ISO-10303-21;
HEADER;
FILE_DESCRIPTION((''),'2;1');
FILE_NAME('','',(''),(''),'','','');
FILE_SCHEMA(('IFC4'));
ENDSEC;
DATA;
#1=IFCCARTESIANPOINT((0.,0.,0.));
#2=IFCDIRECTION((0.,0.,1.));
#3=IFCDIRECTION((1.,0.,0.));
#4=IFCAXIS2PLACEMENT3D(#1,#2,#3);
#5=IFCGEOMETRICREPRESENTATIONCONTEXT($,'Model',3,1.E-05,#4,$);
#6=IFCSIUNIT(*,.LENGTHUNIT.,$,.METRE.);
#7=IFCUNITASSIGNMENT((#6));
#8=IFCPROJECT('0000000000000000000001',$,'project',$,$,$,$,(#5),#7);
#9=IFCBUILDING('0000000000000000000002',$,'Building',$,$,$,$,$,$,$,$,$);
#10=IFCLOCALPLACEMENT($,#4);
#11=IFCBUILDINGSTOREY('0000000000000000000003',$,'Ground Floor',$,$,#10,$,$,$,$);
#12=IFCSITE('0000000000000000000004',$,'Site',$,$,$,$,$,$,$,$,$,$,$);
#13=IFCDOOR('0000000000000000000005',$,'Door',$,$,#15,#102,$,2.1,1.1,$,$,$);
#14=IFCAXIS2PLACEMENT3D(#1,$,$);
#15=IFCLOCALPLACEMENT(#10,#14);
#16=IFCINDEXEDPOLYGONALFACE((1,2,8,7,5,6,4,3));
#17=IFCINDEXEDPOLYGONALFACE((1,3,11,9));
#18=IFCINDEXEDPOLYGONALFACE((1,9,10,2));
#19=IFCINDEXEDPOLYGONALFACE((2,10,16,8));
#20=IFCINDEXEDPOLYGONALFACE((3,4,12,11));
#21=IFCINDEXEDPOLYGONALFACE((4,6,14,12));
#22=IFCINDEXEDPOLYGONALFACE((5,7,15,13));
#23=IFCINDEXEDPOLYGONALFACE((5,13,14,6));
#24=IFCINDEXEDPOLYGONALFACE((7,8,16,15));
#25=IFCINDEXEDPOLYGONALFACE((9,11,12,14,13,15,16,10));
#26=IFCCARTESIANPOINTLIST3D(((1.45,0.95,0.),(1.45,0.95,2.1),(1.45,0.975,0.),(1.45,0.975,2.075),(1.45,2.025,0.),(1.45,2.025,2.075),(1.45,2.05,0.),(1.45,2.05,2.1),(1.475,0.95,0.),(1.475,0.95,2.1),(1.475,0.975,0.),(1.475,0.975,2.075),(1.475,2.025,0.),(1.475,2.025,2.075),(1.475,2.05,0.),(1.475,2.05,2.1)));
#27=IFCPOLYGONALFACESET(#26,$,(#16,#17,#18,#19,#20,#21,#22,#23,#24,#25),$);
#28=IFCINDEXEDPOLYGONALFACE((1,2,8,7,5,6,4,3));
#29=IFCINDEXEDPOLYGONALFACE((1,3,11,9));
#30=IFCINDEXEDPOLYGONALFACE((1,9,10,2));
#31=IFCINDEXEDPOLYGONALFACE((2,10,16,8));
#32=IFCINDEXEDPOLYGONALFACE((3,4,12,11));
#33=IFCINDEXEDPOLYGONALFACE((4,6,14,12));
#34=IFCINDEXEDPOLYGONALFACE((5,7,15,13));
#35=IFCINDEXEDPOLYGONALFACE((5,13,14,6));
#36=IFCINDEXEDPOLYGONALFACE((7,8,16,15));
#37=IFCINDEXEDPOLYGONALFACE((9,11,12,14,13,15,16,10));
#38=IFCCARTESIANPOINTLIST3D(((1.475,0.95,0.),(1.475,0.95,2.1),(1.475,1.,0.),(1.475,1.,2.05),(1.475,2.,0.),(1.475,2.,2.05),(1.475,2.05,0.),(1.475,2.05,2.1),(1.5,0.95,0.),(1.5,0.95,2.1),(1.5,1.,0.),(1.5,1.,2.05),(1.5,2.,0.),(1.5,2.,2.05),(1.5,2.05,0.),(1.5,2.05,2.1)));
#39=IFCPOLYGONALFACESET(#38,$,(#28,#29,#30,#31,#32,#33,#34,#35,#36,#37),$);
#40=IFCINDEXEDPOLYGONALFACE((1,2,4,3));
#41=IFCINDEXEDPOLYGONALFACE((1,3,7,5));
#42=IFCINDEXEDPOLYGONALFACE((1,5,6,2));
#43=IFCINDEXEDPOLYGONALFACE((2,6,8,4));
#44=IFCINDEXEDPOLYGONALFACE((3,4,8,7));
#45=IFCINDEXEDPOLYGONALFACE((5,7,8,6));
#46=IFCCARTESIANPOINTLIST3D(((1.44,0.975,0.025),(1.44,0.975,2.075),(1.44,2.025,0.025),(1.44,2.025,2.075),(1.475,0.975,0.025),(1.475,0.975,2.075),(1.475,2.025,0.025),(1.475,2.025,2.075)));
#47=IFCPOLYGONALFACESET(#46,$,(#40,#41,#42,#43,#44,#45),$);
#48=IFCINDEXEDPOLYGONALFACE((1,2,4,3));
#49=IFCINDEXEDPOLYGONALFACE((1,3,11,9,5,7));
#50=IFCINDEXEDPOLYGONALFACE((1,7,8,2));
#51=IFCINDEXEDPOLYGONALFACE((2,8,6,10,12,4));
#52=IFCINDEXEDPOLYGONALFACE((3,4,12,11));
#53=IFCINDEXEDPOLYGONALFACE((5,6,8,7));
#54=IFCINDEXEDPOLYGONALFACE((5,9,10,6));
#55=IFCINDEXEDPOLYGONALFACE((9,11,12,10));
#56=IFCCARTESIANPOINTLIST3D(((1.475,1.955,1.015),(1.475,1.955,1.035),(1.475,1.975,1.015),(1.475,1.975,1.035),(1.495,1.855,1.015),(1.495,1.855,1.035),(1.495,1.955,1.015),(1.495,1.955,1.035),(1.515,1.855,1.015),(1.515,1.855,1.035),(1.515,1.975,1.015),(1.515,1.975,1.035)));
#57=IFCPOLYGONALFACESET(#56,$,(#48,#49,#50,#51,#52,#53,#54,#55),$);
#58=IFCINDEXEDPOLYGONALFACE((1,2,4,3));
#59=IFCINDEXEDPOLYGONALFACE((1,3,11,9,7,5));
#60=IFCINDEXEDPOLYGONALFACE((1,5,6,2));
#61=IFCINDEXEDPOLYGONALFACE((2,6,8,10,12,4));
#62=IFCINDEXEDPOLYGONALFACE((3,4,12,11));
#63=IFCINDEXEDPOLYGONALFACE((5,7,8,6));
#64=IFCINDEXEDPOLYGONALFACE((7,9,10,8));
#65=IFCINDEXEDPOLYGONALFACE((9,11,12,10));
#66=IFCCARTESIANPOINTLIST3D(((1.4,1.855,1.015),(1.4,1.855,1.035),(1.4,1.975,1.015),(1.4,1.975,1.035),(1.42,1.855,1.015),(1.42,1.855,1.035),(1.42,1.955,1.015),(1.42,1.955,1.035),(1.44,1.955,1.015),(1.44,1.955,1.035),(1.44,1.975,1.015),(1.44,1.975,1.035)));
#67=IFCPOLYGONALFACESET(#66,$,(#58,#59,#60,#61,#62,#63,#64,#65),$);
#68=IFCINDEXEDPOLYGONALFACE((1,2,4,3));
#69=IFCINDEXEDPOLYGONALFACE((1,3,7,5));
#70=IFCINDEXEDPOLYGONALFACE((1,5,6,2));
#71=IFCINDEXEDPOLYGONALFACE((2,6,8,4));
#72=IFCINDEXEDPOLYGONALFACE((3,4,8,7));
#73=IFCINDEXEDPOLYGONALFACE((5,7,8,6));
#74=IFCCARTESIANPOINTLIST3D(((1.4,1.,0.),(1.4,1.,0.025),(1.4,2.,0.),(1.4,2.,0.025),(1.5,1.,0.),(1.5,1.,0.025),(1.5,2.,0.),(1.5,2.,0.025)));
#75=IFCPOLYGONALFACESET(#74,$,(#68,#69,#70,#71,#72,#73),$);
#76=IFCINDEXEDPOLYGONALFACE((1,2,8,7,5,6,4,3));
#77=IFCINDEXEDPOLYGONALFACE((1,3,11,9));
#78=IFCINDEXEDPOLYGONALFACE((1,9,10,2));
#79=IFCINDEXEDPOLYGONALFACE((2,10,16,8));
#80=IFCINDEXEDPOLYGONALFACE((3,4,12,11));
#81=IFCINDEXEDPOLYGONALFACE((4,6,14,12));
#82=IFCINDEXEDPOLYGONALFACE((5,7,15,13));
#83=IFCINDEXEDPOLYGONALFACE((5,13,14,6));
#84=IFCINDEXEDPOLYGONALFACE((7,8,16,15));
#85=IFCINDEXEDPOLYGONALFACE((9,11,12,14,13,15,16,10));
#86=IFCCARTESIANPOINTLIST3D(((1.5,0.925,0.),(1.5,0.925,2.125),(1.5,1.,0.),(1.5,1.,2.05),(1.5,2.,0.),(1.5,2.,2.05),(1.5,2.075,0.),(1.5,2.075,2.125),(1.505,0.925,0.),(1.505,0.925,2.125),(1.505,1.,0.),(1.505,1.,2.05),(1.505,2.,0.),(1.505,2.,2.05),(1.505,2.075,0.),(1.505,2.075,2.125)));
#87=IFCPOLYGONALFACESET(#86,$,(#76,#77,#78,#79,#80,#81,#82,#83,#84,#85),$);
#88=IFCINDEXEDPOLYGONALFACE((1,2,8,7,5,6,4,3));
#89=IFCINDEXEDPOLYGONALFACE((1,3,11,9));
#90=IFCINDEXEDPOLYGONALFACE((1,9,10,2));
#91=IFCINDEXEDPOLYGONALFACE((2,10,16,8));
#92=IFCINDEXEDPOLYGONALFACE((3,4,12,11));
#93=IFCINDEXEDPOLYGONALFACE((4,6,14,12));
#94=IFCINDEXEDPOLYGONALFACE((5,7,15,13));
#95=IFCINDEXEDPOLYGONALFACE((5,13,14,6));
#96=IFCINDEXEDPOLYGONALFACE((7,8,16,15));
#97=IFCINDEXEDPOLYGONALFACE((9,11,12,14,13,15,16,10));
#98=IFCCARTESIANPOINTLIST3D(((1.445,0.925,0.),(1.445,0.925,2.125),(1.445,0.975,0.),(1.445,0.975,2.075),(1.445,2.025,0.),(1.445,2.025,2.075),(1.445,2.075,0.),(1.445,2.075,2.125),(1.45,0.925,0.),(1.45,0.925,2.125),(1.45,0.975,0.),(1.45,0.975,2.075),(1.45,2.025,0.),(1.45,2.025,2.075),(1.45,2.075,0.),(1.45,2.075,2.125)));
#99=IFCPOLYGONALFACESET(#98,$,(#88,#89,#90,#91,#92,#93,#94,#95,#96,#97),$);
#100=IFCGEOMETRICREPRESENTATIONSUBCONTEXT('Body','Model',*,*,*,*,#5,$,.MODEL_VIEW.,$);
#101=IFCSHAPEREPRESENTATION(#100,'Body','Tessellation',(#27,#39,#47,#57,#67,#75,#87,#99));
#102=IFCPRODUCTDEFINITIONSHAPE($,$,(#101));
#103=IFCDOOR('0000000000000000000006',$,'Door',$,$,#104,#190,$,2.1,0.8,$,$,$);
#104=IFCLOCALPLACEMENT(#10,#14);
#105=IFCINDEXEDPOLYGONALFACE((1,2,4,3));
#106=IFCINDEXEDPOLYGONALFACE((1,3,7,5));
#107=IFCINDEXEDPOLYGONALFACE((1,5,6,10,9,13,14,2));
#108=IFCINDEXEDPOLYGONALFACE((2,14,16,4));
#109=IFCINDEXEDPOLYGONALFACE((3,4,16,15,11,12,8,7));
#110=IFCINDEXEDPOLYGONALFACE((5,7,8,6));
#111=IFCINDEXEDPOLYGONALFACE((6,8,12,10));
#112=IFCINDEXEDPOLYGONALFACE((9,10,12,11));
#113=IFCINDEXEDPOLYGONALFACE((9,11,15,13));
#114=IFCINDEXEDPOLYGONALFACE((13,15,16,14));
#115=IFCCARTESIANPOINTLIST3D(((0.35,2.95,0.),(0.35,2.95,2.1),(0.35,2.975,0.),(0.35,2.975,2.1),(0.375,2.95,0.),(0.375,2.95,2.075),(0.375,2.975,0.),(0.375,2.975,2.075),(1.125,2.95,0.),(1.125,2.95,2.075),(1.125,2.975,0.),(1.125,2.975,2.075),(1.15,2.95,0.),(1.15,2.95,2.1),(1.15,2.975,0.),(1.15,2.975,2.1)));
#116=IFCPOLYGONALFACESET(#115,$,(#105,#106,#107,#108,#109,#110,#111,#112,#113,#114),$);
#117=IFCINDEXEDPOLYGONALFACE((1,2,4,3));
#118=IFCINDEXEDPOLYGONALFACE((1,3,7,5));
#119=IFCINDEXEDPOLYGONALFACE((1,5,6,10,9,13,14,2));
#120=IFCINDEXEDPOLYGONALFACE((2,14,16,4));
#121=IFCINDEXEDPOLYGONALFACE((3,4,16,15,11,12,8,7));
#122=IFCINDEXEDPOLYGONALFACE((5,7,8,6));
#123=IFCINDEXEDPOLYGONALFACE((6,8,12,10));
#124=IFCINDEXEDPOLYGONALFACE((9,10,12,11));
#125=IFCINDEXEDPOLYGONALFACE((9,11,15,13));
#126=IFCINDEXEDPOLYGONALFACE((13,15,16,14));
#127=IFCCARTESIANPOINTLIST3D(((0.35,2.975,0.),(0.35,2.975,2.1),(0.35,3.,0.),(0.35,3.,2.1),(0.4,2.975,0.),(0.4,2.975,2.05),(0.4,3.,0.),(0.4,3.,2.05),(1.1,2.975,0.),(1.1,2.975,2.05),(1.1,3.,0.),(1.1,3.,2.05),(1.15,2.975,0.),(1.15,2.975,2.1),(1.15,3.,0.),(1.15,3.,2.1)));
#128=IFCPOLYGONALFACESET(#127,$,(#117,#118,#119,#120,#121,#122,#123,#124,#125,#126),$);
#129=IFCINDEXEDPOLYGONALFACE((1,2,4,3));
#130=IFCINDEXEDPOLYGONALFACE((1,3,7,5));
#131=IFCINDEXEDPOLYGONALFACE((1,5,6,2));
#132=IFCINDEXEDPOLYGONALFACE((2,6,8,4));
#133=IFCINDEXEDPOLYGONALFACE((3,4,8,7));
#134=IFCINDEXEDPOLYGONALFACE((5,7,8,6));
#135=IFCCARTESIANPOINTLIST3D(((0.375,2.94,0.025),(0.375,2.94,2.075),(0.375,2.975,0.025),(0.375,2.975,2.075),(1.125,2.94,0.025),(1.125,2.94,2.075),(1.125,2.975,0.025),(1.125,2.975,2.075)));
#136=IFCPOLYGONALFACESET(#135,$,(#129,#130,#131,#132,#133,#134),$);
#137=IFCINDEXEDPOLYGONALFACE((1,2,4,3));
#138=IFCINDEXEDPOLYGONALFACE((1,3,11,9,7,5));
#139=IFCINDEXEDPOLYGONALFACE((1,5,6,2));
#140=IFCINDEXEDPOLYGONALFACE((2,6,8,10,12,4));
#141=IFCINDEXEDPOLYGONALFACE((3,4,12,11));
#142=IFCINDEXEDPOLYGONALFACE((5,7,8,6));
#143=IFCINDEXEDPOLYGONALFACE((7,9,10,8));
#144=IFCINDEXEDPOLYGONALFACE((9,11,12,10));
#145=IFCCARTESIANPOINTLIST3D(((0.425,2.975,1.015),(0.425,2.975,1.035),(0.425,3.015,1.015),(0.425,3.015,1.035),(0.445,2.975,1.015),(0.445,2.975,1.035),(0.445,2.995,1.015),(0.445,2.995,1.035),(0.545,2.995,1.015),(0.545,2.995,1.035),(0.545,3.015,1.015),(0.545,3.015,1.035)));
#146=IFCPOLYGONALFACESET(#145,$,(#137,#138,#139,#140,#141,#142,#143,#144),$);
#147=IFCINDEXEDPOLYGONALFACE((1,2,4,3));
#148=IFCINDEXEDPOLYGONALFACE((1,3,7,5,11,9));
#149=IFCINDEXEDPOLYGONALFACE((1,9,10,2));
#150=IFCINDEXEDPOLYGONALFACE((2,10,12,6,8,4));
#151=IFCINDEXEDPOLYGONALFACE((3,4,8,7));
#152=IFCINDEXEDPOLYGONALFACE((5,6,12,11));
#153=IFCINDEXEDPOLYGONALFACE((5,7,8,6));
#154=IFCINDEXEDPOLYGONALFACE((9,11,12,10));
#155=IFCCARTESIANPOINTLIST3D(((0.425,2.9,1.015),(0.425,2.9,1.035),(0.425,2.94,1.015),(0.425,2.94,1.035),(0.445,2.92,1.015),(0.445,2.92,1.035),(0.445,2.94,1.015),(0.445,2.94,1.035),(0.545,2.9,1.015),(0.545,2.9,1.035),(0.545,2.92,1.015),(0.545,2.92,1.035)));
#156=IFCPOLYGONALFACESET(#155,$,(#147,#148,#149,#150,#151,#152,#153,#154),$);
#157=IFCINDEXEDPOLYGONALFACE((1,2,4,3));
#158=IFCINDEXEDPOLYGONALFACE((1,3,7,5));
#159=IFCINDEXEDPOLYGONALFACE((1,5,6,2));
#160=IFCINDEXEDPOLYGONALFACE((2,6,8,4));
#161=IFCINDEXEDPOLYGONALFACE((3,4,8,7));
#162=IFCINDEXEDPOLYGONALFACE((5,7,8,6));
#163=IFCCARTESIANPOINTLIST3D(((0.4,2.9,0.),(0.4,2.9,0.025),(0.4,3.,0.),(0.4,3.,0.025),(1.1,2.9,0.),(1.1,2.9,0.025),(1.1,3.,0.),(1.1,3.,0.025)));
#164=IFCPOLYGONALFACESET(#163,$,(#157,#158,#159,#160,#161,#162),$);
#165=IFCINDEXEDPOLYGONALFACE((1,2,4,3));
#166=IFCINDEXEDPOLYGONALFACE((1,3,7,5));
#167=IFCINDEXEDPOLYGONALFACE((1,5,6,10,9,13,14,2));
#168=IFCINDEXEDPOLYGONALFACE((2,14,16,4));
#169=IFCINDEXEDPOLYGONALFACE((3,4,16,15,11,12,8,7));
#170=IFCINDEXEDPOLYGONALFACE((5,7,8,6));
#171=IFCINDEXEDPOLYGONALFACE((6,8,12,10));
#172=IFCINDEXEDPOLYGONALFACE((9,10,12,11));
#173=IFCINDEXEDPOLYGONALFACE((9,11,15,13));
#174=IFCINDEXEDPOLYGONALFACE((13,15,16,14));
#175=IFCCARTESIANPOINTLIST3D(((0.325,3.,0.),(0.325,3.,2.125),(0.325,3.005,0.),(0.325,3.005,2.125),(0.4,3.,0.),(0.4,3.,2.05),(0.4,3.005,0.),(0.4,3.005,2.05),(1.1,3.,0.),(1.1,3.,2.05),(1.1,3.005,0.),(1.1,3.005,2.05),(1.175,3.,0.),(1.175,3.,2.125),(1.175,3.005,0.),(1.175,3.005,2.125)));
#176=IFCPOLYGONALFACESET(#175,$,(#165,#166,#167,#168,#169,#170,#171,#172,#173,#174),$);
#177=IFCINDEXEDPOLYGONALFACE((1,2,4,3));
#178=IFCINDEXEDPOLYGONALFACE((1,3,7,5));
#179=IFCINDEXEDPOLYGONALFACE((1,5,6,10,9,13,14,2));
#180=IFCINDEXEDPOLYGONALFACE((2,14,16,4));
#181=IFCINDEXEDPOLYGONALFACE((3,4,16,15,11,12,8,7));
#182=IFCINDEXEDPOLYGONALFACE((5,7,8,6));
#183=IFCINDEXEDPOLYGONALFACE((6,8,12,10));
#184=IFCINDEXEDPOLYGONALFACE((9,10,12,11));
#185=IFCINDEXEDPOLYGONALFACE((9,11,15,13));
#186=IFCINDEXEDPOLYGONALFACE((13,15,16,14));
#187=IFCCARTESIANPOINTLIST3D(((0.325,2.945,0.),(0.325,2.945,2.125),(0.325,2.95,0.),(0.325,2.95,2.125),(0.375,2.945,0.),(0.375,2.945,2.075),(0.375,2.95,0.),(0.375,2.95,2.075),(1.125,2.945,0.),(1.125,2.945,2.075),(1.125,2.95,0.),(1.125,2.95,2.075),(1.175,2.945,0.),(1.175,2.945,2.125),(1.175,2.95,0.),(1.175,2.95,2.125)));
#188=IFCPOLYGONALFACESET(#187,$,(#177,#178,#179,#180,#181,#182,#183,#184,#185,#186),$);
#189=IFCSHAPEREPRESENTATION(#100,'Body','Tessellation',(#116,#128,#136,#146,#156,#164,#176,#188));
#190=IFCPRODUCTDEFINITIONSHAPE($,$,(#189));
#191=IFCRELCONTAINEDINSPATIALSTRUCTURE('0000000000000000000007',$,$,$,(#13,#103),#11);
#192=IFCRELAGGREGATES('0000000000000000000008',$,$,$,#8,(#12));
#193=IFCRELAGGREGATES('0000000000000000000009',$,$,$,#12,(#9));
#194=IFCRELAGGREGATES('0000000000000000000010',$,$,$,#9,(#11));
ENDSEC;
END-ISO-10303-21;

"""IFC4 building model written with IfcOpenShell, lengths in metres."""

from ifc_helpers import new_model, si_unit, frame, origin_with_axes, place, context, subcontext, project, spatial, line, indexed_curve, outline, extrude, element, save


model = new_model("IFC4")

# Units and contexts
model_context = context("Model", 3, precision=1e-05, world=origin_with_axes())
body_context = subcontext(model_context, "Body", "Model", "MODEL_VIEW")
ifc_project = project(units=[si_unit("LENGTHUNIT", "METRE")], contexts=[model_context])

# Site, building, storey
site = spatial("IfcSite", under=ifc_project, Name="Site")
building = spatial("IfcBuilding", under=site, Name="Building")
storey_placement = place(None, origin_with_axes())
storey = spatial("IfcBuildingStorey", under=building, at=storey_placement, Name="Ground Floor")

# Doors
door_1_placement = place(storey_placement, frame((1.5, 0.95, 0.0), z_axis=(0.0, 0.0, 1.0), x_axis=(0.0, 1.0, 0.0)))
element("IfcDoor", 1, at=door_1_placement, inside=storey, Name="Door", OverallHeight=2.1, OverallWidth=1.1, context=body_context, shape_type="SweptSolid", body=[
    extrude(outline(indexed_curve([(0.0, 0.0), (0.0, 2.1), (1.1, 2.1), (1.1, 0.0), (1.075, 0.0), (1.075, 2.075), (0.025, 2.075), (0.025, 0.0)], segments=[line(1, 2, 3, 4, 5, 6, 7, 8, 1)])), frame((0.0, 0.025, 0.0), z_axis=(0.0, -1.0, 0.0), x_axis=(1.0, 0.0, 0.0)), (0.0, 0.0, -1.0), 0.025),
    extrude(outline(indexed_curve([(0.0, 0.0), (0.0, 2.1), (1.1, 2.1), (1.1, 0.0), (1.05, 0.0), (1.05, 2.05), (0.05, 2.05), (0.05, 0.0)], segments=[line(1, 2, 3, 4, 5, 6, 7, 8, 1)])), frame((0.0, 0.0, 0.0), z_axis=(0.0, -1.0, 0.0), x_axis=(1.0, 0.0, 0.0)), (0.0, 0.0, -1.0), 0.025),
    extrude(outline(indexed_curve([(0.0, 0.0), (1.05, 0.0), (1.05, 0.035), (0.0, 0.035)], segments=[line(1, 2, 3, 4, 1)])), frame((0.025, 0.025, 0.025), z_axis=(0.0, 0.0, 1.0), x_axis=(1.0, 0.0, 0.0)), (0.0, 0.0, 1.0), 2.05),
    extrude(outline(indexed_curve([(0.0, 0.0), (0.0, -0.04), (-0.12, -0.04), (-0.12, -0.02), (-0.02, -0.02), (-0.02, 0.0)], segments=[line(1, 2, 3, 4, 5, 6, 1)])), frame((1.025, 0.025, 1.015), z_axis=(0.0, 0.0, 1.0), x_axis=(1.0, 0.0, 0.0)), (0.0, 0.0, 1.0), 0.02),
    extrude(outline(indexed_curve([(0.0, 0.0), (0.0, 0.04), (-0.12, 0.04), (-0.12, 0.02), (-0.02, 0.02), (-0.02, 0.0)], segments=[line(1, 2, 3, 4, 5, 6, 1)])), frame((1.025, 0.06, 1.015), z_axis=(0.0, 0.0, 1.0), x_axis=(1.0, 0.0, 0.0)), (0.0, 0.0, 1.0), 0.02),
    extrude(outline(indexed_curve([(0.0, 0.0), (1.0, 0.0), (1.0, 0.1), (0.0, 0.1)], segments=[line(1, 2, 3, 4, 1)])), frame((0.05, 0.0, 0.0), z_axis=(0.0, 0.0, 1.0), x_axis=(1.0, 0.0, 0.0)), (0.0, 0.0, 1.0), 0.025),
    extrude(outline(indexed_curve([(0.0, 0.0), (0.0, 2.125), (1.15, 2.125), (1.15, 0.0), (1.075, 0.0), (1.075, 2.05), (0.075, 2.05), (0.075, 0.0)], segments=[line(1, 2, 3, 4, 5, 6, 7, 8, 1)])), frame((-0.025, -0.005, 0.0), z_axis=(0.0, -1.0, 0.0), x_axis=(1.0, 0.0, 0.0)), (0.0, 0.0, -1.0), 0.005),
    extrude(outline(indexed_curve([(0.0, 0.0), (0.0, 2.125), (1.15, 2.125), (1.15, 0.0), (1.1, 0.0), (1.1, 2.075), (0.05, 2.075), (0.05, 0.0)], segments=[line(1, 2, 3, 4, 5, 6, 7, 8, 1)])), frame((-0.025, 0.05, 0.0), z_axis=(0.0, -1.0, 0.0), x_axis=(1.0, 0.0, 0.0)), (0.0, 0.0, -1.0), 0.005),
])
door_2_placement = place(storey_placement, frame((1.15, 3.0, 0.0), z_axis=(0.0, 0.0, 1.0), x_axis=(-1.0, 0.0, 0.0)))
element("IfcDoor", 2, at=door_2_placement, inside=storey, Name="Door", OverallHeight=2.1, OverallWidth=0.8, context=body_context, shape_type="SweptSolid", body=[
    extrude(outline(indexed_curve([(0.0, 0.0), (0.0, 2.1), (0.8, 2.1), (0.8, 0.0), (0.775, 0.0), (0.775, 2.075), (0.025, 2.075), (0.025, 0.0)], segments=[line(1, 2, 3, 4, 5, 6, 7, 8, 1)])), frame((0.0, 0.025, 0.0), z_axis=(0.0, -1.0, 0.0), x_axis=(1.0, 0.0, 0.0)), (0.0, 0.0, -1.0), 0.025),
    extrude(outline(indexed_curve([(0.0, 0.0), (0.0, 2.1), (0.8, 2.1), (0.8, 0.0), (0.75, 0.0), (0.75, 2.05), (0.05, 2.05), (0.05, 0.0)], segments=[line(1, 2, 3, 4, 5, 6, 7, 8, 1)])), frame((0.0, 0.0, 0.0), z_axis=(0.0, -1.0, 0.0), x_axis=(1.0, 0.0, 0.0)), (0.0, 0.0, -1.0), 0.025),
    extrude(outline(indexed_curve([(0.0, 0.0), (0.75, 0.0), (0.75, 0.035), (0.0, 0.035)], segments=[line(1, 2, 3, 4, 1)])), frame((0.025, 0.025, 0.025), z_axis=(0.0, 0.0, 1.0), x_axis=(1.0, 0.0, 0.0)), (0.0, 0.0, 1.0), 2.05),
    extrude(outline(indexed_curve([(0.0, 0.0), (0.0, -0.04), (-0.12, -0.04), (-0.12, -0.02), (-0.02, -0.02), (-0.02, 0.0)], segments=[line(1, 2, 3, 4, 5, 6, 1)])), frame((0.725, 0.025, 1.015), z_axis=(0.0, 0.0, 1.0), x_axis=(1.0, 0.0, 0.0)), (0.0, 0.0, 1.0), 0.02),
    extrude(outline(indexed_curve([(0.0, 0.0), (0.0, 0.04), (-0.12, 0.04), (-0.12, 0.02), (-0.02, 0.02), (-0.02, 0.0)], segments=[line(1, 2, 3, 4, 5, 6, 1)])), frame((0.725, 0.06, 1.015), z_axis=(0.0, 0.0, 1.0), x_axis=(1.0, 0.0, 0.0)), (0.0, 0.0, 1.0), 0.02),
    extrude(outline(indexed_curve([(0.0, 0.0), (0.7, 0.0), (0.7, 0.1), (0.0, 0.1)], segments=[line(1, 2, 3, 4, 1)])), frame((0.05, 0.0, 0.0), z_axis=(0.0, 0.0, 1.0), x_axis=(1.0, 0.0, 0.0)), (0.0, 0.0, 1.0), 0.025),
    extrude(outline(indexed_curve([(0.0, 0.0), (0.0, 2.125), (0.85, 2.125), (0.85, 0.0), (0.775, 0.0), (0.775, 2.05), (0.075, 2.05), (0.075, 0.0)], segments=[line(1, 2, 3, 4, 5, 6, 7, 8, 1)])), frame((-0.025, -0.005, 0.0), z_axis=(0.0, -1.0, 0.0), x_axis=(1.0, 0.0, 0.0)), (0.0, 0.0, -1.0), 0.005),
    extrude(outline(indexed_curve([(0.0, 0.0), (0.0, 2.125), (0.85, 2.125), (0.85, 0.0), (0.8, 0.0), (0.8, 2.075), (0.05, 2.075), (0.05, 0.0)], segments=[line(1, 2, 3, 4, 5, 6, 7, 8, 1)])), frame((-0.025, 0.05, 0.0), z_axis=(0.0, -1.0, 0.0), x_axis=(1.0, 0.0, 0.0)), (0.0, 0.0, -1.0), 0.005),
])

save(model, "model.ifc")
